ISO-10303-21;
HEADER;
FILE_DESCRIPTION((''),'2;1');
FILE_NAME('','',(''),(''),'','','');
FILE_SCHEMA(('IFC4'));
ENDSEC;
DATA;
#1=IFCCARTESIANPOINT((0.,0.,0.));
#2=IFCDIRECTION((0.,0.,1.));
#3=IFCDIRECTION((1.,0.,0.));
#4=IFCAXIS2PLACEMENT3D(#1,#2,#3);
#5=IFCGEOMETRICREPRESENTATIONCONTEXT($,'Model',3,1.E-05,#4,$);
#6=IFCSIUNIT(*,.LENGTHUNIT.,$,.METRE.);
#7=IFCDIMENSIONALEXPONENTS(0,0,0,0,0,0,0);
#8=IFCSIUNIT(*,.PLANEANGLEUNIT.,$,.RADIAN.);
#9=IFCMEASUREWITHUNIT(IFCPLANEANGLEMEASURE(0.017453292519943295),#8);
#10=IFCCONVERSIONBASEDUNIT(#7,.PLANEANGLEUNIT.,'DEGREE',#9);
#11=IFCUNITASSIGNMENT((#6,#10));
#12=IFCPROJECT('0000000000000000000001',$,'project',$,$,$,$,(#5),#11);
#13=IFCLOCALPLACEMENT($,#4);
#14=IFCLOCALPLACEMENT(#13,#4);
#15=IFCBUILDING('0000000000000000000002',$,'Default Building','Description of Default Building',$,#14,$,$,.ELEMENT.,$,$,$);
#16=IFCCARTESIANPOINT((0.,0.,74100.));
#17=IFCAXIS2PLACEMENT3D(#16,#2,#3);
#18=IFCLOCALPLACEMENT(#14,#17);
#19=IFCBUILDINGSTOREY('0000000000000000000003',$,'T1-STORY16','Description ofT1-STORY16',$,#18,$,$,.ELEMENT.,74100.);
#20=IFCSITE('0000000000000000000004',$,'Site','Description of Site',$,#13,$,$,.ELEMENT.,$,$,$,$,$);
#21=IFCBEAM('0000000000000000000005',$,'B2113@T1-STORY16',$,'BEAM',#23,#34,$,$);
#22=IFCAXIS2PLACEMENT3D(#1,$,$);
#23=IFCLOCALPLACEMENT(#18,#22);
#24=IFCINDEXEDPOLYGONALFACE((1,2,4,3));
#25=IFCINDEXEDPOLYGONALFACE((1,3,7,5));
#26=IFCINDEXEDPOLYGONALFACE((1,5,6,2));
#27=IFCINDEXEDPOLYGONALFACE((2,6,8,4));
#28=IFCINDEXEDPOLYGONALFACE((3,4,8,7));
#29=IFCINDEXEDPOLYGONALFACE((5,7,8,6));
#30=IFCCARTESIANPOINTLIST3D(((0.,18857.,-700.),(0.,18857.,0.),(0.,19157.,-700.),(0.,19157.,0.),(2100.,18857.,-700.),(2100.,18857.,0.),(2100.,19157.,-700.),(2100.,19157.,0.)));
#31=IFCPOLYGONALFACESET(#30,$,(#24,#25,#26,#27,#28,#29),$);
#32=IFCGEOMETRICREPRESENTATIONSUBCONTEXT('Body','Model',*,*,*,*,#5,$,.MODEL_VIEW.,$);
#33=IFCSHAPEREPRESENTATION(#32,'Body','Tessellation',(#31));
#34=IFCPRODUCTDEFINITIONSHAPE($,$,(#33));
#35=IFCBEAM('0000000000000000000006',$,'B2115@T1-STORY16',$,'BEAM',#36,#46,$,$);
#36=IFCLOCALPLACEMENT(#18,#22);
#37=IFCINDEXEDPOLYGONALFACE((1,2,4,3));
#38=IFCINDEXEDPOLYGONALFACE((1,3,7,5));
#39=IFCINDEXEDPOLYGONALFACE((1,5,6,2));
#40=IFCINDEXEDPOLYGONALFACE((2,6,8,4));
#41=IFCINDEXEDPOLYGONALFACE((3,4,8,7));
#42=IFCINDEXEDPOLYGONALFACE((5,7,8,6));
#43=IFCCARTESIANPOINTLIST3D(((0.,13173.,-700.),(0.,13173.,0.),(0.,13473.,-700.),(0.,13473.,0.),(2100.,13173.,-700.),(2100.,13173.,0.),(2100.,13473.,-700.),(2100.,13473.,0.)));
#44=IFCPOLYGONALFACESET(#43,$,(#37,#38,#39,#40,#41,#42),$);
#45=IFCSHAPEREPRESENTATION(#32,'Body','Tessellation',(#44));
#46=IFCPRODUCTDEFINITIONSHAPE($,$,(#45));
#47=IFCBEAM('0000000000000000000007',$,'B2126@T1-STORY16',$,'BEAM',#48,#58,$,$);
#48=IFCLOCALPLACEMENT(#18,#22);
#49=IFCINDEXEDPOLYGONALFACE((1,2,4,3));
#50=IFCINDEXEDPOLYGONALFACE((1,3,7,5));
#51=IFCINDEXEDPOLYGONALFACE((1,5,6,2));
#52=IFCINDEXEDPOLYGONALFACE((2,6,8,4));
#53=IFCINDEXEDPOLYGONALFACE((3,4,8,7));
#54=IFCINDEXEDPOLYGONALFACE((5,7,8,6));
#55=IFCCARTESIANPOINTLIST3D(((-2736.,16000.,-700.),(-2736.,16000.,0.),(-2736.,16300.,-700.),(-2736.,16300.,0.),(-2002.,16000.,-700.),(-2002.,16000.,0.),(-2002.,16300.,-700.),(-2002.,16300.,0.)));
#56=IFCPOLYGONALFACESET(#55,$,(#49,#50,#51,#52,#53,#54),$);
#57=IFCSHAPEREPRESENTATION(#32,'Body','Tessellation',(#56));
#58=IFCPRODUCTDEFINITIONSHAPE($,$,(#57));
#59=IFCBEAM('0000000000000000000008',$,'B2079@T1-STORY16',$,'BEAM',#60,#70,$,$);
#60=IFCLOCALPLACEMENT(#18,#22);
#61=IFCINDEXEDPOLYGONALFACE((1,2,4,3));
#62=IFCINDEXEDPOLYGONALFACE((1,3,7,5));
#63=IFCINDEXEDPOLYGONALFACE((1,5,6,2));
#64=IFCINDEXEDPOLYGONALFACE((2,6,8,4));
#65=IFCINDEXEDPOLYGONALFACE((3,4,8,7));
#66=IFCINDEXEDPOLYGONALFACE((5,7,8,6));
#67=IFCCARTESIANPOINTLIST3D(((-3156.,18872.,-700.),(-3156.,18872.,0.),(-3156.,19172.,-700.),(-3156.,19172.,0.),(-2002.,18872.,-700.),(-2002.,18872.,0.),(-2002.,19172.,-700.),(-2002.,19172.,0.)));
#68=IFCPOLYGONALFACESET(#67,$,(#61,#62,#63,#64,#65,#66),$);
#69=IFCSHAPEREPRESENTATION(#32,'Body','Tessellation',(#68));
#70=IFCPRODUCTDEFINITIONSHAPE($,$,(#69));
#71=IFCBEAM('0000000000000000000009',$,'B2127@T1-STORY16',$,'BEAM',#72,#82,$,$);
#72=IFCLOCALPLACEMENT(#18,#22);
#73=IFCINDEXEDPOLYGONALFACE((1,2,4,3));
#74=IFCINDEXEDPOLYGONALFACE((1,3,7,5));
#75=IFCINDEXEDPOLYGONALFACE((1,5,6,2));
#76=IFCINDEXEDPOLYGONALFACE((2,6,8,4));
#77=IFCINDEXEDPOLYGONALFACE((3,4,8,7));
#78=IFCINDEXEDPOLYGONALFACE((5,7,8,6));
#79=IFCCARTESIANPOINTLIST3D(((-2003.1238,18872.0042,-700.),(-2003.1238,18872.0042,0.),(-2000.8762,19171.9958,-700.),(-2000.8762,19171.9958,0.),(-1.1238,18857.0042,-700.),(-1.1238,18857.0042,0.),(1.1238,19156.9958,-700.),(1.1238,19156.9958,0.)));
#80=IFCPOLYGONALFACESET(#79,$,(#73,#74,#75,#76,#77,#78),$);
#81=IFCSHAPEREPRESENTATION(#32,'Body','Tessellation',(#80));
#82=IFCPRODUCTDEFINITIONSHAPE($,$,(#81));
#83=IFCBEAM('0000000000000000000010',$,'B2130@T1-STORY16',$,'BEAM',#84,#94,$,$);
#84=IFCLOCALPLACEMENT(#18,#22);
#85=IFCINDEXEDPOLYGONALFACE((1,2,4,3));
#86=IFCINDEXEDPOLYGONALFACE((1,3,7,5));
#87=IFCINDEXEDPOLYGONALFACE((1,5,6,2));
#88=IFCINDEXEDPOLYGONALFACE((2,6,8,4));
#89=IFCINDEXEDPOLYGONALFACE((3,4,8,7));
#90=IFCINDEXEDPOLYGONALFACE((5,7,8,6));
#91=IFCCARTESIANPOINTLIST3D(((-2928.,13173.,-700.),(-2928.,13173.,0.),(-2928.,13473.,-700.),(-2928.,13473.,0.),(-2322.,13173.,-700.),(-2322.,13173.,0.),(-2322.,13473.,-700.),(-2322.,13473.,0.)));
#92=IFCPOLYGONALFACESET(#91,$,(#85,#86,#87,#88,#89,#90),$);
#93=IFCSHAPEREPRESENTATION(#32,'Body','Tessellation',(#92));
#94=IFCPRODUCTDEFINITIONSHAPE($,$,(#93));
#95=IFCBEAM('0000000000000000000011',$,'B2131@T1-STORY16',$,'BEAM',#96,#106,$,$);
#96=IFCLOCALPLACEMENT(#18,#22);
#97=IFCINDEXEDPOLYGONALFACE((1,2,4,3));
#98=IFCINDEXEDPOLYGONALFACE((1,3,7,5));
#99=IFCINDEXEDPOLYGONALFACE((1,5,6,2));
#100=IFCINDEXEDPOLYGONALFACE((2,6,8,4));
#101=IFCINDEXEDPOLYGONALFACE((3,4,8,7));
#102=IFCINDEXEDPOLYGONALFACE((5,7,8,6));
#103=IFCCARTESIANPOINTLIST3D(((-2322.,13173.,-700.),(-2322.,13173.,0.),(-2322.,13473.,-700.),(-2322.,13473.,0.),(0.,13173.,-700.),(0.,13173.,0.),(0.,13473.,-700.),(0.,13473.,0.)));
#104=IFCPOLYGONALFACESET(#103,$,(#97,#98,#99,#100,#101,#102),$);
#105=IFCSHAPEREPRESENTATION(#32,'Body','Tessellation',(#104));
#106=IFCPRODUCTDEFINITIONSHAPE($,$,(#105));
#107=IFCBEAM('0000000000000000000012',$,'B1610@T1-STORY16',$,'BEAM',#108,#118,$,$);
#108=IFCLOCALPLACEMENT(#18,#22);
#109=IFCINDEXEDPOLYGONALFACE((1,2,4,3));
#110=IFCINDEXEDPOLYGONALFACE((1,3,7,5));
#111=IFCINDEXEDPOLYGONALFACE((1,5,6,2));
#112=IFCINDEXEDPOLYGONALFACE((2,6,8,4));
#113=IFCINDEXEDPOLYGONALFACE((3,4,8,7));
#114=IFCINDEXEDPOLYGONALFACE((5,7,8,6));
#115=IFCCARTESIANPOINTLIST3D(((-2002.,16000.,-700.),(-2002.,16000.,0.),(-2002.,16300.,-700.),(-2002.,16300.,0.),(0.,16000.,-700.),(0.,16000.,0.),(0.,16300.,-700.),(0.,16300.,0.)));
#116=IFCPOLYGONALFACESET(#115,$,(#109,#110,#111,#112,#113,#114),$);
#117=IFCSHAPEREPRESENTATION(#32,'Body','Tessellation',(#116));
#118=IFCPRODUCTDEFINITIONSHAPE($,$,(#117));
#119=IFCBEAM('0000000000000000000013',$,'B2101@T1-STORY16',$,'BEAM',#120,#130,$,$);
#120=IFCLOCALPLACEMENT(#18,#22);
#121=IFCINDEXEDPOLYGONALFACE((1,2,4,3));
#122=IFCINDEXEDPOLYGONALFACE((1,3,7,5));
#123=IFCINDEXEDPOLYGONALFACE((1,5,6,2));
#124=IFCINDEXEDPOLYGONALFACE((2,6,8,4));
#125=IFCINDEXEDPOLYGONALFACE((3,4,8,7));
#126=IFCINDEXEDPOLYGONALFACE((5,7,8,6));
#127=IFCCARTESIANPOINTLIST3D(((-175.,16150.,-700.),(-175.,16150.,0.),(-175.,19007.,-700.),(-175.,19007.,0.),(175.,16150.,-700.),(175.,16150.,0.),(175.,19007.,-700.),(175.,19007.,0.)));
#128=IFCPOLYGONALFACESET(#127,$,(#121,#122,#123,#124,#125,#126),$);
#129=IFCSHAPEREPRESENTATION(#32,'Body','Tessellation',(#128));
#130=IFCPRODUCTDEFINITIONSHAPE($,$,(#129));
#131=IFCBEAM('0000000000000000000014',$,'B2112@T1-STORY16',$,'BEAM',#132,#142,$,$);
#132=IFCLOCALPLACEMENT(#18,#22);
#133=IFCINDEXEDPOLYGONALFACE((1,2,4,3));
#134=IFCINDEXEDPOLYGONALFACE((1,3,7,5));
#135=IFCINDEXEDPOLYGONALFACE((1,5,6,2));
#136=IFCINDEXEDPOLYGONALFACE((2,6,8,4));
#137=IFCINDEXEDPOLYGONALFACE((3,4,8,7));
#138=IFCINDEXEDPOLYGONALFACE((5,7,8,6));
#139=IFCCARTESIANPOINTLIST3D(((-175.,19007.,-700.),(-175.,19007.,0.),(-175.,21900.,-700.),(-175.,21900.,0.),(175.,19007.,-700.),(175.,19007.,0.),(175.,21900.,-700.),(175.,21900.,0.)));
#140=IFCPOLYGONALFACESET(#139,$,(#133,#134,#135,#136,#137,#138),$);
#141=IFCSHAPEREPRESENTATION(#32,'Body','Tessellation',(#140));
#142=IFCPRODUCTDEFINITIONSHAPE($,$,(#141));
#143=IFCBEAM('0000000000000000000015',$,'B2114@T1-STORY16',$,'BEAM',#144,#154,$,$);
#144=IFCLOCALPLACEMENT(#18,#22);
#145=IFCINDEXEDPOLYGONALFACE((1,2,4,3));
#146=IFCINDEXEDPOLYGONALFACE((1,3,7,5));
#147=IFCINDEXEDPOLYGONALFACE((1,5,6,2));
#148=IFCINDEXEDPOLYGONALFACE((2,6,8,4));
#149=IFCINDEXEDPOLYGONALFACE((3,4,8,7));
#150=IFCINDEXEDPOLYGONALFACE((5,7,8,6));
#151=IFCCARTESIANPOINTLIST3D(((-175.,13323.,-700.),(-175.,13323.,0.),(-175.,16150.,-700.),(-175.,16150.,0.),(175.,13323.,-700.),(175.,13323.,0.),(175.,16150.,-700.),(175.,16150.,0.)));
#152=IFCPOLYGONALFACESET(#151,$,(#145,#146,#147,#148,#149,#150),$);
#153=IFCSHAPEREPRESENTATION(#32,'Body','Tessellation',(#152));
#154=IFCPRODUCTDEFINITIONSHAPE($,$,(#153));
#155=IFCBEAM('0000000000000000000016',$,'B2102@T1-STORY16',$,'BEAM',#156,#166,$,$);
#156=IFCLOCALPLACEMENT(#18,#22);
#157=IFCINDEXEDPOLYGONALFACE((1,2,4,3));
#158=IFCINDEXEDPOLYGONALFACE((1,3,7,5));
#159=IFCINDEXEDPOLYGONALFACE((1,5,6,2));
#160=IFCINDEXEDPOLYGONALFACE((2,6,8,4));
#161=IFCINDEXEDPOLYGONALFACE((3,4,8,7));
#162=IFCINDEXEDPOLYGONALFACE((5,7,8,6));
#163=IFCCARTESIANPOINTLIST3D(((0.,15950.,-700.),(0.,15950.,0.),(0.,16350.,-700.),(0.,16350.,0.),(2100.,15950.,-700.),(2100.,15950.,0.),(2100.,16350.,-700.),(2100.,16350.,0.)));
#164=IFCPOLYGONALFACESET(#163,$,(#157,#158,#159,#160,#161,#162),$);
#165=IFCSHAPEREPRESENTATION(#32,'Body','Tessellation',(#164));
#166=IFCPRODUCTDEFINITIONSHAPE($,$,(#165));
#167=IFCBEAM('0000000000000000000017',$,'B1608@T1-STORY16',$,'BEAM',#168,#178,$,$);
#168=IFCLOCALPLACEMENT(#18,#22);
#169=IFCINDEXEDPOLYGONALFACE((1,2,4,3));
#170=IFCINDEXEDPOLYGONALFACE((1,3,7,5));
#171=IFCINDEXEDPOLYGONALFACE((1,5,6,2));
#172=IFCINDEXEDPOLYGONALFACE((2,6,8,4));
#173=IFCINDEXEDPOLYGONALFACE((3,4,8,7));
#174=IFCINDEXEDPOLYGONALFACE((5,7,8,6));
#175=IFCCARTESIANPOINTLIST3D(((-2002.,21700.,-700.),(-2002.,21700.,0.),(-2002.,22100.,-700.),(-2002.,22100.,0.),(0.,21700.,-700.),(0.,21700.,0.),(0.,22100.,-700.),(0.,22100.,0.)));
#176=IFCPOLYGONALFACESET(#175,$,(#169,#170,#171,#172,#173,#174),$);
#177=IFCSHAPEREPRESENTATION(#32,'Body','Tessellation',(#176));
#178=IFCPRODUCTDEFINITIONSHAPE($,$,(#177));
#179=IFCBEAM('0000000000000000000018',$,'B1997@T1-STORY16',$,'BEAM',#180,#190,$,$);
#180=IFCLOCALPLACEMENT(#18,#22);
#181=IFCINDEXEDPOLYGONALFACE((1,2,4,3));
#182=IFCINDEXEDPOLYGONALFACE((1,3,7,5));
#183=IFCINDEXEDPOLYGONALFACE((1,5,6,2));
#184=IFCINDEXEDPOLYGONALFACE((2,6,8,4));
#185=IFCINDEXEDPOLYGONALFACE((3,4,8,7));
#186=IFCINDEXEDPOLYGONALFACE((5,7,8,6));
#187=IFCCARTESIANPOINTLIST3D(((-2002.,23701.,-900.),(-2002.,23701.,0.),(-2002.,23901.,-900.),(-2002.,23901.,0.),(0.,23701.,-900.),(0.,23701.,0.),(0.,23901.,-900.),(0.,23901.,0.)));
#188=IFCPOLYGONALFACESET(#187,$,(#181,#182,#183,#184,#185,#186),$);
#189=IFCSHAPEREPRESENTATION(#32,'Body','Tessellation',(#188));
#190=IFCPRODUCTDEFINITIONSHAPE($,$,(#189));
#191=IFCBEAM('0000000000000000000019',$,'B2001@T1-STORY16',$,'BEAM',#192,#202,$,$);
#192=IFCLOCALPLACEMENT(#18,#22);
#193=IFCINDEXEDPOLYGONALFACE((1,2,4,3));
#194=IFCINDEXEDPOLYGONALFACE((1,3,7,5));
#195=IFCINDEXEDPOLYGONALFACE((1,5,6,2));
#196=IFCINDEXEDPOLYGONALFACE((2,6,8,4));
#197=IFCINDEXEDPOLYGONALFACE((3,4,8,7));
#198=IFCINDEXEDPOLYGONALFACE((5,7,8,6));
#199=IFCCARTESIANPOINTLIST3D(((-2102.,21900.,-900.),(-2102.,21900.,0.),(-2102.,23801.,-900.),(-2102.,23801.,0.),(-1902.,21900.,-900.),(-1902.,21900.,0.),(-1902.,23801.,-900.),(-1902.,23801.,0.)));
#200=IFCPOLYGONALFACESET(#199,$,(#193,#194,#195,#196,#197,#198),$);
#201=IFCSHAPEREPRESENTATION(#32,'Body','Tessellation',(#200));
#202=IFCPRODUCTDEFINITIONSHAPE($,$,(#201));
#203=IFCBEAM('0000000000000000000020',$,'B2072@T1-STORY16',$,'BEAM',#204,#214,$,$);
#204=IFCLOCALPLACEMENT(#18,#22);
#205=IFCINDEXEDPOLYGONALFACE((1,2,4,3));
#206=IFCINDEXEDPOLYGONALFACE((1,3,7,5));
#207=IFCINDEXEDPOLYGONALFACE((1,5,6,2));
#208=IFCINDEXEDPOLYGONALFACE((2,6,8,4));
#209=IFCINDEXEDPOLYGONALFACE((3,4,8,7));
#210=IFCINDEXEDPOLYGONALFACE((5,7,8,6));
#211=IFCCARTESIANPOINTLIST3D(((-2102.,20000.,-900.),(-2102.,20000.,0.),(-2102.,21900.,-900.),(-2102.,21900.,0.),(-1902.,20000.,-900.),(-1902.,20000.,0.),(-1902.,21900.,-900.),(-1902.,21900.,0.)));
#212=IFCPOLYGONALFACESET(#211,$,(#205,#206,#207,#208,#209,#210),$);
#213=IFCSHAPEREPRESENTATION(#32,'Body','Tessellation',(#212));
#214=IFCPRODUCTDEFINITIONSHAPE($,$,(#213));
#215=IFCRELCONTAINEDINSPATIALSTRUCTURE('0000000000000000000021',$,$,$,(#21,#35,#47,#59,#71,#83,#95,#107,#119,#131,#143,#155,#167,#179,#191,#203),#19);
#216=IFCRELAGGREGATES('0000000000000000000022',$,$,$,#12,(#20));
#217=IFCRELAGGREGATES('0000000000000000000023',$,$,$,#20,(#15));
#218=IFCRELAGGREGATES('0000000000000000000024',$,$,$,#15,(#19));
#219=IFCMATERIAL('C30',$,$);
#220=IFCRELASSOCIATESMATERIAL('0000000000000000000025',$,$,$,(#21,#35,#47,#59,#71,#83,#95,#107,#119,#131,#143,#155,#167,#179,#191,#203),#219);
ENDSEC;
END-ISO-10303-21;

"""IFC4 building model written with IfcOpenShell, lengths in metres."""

from ifc_helpers import new_model, entity, si_unit, converted_unit, frame, origin_with_axes, place, context, subcontext, project, spatial, rectangle, extrude, material, element, save


model = new_model("IFC4")

# Units and contexts
model_context = context("Model", 3, precision=1e-05, world=origin_with_axes())
body_context = subcontext(model_context, "Body", "Model", "MODEL_VIEW")
ifc_project = project(units=[si_unit("LENGTHUNIT", "METRE"), converted_unit("PLANEANGLEUNIT", "DEGREE", entity("IfcPlaneAngleMeasure", 0.017453292519943295), si_unit("PLANEANGLEUNIT", "RADIAN"), dimensions=[0, 0, 0, 0, 0, 0, 0])], contexts=[model_context])

# Site, building, storey
site_placement = place(None, origin_with_axes())
site = spatial("IfcSite", under=ifc_project, at=site_placement, Name="Site", Description="Description of Site", CompositionType="ELEMENT")
building_placement = place(site_placement, origin_with_axes())
building = spatial("IfcBuilding", under=site, at=building_placement, Name="Default Building", Description="Description of Default Building", CompositionType="ELEMENT")
storey_placement = place(building_placement, frame((0.0, 0.0, 74100.0), z_axis=(0.0, 0.0, 1.0), x_axis=(1.0, 0.0, 0.0)))
storey = spatial("IfcBuildingStorey", under=building, at=storey_placement, Name="T1-STORY16", Description="Description ofT1-STORY16", CompositionType="ELEMENT", Elevation=74100.0)

# Beams
ifc_material_1 = material(Name="C30")
for number, where, z_axis, x_axis, name in (
    (1, (0.0, 19007.0, -350.0), (1.0, 0.0, 0.0), (0.0, 1.0, 0.0), "B2113@T1-STORY16"),
    (2, (0.0, 13323.0, -350.0), (1.0, 0.0, 0.0), (0.0, 1.0, 0.0), "B2115@T1-STORY16"),
):
    element("IfcBeam", number, at=place(storey_placement, frame(where, z_axis=z_axis, x_axis=x_axis)), inside=storey, material=ifc_material_1, Name=name, ObjectType="BEAM", context=body_context, shape_type="SweptSolid", body=[
        extrude(rectangle(XDim=300.0, YDim=700.0), origin_with_axes(), (0.0, 0.0, 1.0), 2100.0),
    ])
beam_1_placement = place(storey_placement, frame((-2736.0, 16150.0, -350.0), z_axis=(1.0, 0.0, 0.0), x_axis=(0.0, 1.0, 0.0)))
element("IfcBeam", 3, at=beam_1_placement, inside=storey, material=ifc_material_1, Name="B2126@T1-STORY16", ObjectType="BEAM", context=body_context, shape_type="SweptSolid", body=[
    extrude(rectangle(XDim=300.0, YDim=700.0), origin_with_axes(), (0.0, 0.0, 1.0), 734.0),
])
beam_2_placement = place(storey_placement, frame((-3156.0, 19022.0, -350.0), z_axis=(1.0, 0.0, 0.0), x_axis=(0.0, 1.0, 0.0)))
element("IfcBeam", 4, at=beam_2_placement, inside=storey, material=ifc_material_1, Name="B2079@T1-STORY16", ObjectType="BEAM", context=body_context, shape_type="SweptSolid", body=[
    extrude(rectangle(XDim=300.0, YDim=700.0), origin_with_axes(), (0.0, 0.0, 1.0), 1154.0),
])
beam_3_placement = place(storey_placement, frame((-2002.0, 19022.0, -350.0), z_axis=(0.999972, -0.007492, 0.0), x_axis=(0.007492, 0.999972, 0.0)))
element("IfcBeam", 5, at=beam_3_placement, inside=storey, material=ifc_material_1, Name="B2127@T1-STORY16", ObjectType="BEAM", context=body_context, shape_type="SweptSolid", body=[
    extrude(rectangle(XDim=300.0, YDim=700.0), origin_with_axes(), (0.0, 0.0, 1.0), 2002.0562),
])
beam_4_placement = place(storey_placement, frame((-2928.0, 13323.0, -350.0), z_axis=(1.0, 0.0, 0.0), x_axis=(0.0, 1.0, 0.0)))
element("IfcBeam", 6, at=beam_4_placement, inside=storey, material=ifc_material_1, Name="B2130@T1-STORY16", ObjectType="BEAM", context=body_context, shape_type="SweptSolid", body=[
    extrude(rectangle(XDim=300.0, YDim=700.0), origin_with_axes(), (0.0, 0.0, 1.0), 606.0),
])
beam_5_placement = place(storey_placement, frame((-2322.0, 13323.0, -350.0), z_axis=(1.0, 0.0, 0.0), x_axis=(0.0, 1.0, 0.0)))
element("IfcBeam", 7, at=beam_5_placement, inside=storey, material=ifc_material_1, Name="B2131@T1-STORY16", ObjectType="BEAM", context=body_context, shape_type="SweptSolid", body=[
    extrude(rectangle(XDim=300.0, YDim=700.0), origin_with_axes(), (0.0, 0.0, 1.0), 2322.0),
])
beam_6_placement = place(storey_placement, frame((-2002.0, 16150.0, -350.0), z_axis=(1.0, 0.0, 0.0), x_axis=(0.0, 1.0, 0.0)))
element("IfcBeam", 8, at=beam_6_placement, inside=storey, material=ifc_material_1, Name="B1610@T1-STORY16", ObjectType="BEAM", context=body_context, shape_type="SweptSolid", body=[
    extrude(rectangle(XDim=300.0, YDim=700.0), origin_with_axes(), (0.0, 0.0, 1.0), 2002.0),
])
beam_7_placement = place(storey_placement, frame((0.0, 16150.0, -350.0), z_axis=(0.0, 1.0, 0.0), x_axis=(-1.0, 0.0, 0.0)))
element("IfcBeam", 9, at=beam_7_placement, inside=storey, material=ifc_material_1, Name="B2101@T1-STORY16", ObjectType="BEAM", context=body_context, shape_type="SweptSolid", body=[
    extrude(rectangle(XDim=350.0, YDim=700.0), origin_with_axes(), (0.0, 0.0, 1.0), 2857.0),
])
beam_8_placement = place(storey_placement, frame((0.0, 19007.0, -350.0), z_axis=(0.0, 1.0, 0.0), x_axis=(-1.0, 0.0, 0.0)))
element("IfcBeam", 10, at=beam_8_placement, inside=storey, material=ifc_material_1, Name="B2112@T1-STORY16", ObjectType="BEAM", context=body_context, shape_type="SweptSolid", body=[
    extrude(rectangle(XDim=350.0, YDim=700.0), origin_with_axes(), (0.0, 0.0, 1.0), 2893.0),
])
beam_9_placement = place(storey_placement, frame((0.0, 13323.0, -350.0), z_axis=(0.0, 1.0, 0.0), x_axis=(-1.0, 0.0, 0.0)))
element("IfcBeam", 11, at=beam_9_placement, inside=storey, material=ifc_material_1, Name="B2114@T1-STORY16", ObjectType="BEAM", context=body_context, shape_type="SweptSolid", body=[
    extrude(rectangle(XDim=350.0, YDim=700.0), origin_with_axes(), (0.0, 0.0, 1.0), 2827.0),
])
beam_10_placement = place(storey_placement, frame((0.0, 16150.0, -350.0), z_axis=(1.0, 0.0, 0.0), x_axis=(0.0, 1.0, 0.0)))
element("IfcBeam", 12, at=beam_10_placement, inside=storey, material=ifc_material_1, Name="B2102@T1-STORY16", ObjectType="BEAM", context=body_context, shape_type="SweptSolid", body=[
    extrude(rectangle(XDim=400.0, YDim=700.0), origin_with_axes(), (0.0, 0.0, 1.0), 2100.0),
])
beam_11_placement = place(storey_placement, frame((-2002.0, 21900.0, -350.0), z_axis=(1.0, 0.0, 0.0), x_axis=(0.0, 1.0, 0.0)))
element("IfcBeam", 13, at=beam_11_placement, inside=storey, material=ifc_material_1, Name="B1608@T1-STORY16", ObjectType="BEAM", context=body_context, shape_type="SweptSolid", body=[
    extrude(rectangle(XDim=400.0, YDim=700.0), origin_with_axes(), (0.0, 0.0, 1.0), 2002.0),
])
beam_12_placement = place(storey_placement, frame((-2002.0, 23801.0, -450.0), z_axis=(1.0, 0.0, 0.0), x_axis=(0.0, 1.0, 0.0)))
element("IfcBeam", 14, at=beam_12_placement, inside=storey, material=ifc_material_1, Name="B1997@T1-STORY16", ObjectType="BEAM", context=body_context, shape_type="SweptSolid", body=[
    extrude(rectangle(XDim=200.0, YDim=900.0), origin_with_axes(), (0.0, 0.0, 1.0), 2002.0),
])
beam_13_placement = place(storey_placement, frame((-2002.0, 21900.0, -450.0), z_axis=(0.0, 1.0, 0.0), x_axis=(-1.0, 0.0, 0.0)))
element("IfcBeam", 15, at=beam_13_placement, inside=storey, material=ifc_material_1, Name="B2001@T1-STORY16", ObjectType="BEAM", context=body_context, shape_type="SweptSolid", body=[
    extrude(rectangle(XDim=200.0, YDim=900.0), origin_with_axes(), (0.0, 0.0, 1.0), 1901.0),
])
beam_14_placement = place(storey_placement, frame((-2002.0, 20000.0, -450.0), z_axis=(0.0, 1.0, 0.0), x_axis=(-1.0, 0.0, 0.0)))
element("IfcBeam", 16, at=beam_14_placement, inside=storey, material=ifc_material_1, Name="B2072@T1-STORY16", ObjectType="BEAM", context=body_context, shape_type="SweptSolid", body=[
    extrude(rectangle(XDim=200.0, YDim=900.0), origin_with_axes(), (0.0, 0.0, 1.0), 1900.0),
])

save(model, "model.ifc")
